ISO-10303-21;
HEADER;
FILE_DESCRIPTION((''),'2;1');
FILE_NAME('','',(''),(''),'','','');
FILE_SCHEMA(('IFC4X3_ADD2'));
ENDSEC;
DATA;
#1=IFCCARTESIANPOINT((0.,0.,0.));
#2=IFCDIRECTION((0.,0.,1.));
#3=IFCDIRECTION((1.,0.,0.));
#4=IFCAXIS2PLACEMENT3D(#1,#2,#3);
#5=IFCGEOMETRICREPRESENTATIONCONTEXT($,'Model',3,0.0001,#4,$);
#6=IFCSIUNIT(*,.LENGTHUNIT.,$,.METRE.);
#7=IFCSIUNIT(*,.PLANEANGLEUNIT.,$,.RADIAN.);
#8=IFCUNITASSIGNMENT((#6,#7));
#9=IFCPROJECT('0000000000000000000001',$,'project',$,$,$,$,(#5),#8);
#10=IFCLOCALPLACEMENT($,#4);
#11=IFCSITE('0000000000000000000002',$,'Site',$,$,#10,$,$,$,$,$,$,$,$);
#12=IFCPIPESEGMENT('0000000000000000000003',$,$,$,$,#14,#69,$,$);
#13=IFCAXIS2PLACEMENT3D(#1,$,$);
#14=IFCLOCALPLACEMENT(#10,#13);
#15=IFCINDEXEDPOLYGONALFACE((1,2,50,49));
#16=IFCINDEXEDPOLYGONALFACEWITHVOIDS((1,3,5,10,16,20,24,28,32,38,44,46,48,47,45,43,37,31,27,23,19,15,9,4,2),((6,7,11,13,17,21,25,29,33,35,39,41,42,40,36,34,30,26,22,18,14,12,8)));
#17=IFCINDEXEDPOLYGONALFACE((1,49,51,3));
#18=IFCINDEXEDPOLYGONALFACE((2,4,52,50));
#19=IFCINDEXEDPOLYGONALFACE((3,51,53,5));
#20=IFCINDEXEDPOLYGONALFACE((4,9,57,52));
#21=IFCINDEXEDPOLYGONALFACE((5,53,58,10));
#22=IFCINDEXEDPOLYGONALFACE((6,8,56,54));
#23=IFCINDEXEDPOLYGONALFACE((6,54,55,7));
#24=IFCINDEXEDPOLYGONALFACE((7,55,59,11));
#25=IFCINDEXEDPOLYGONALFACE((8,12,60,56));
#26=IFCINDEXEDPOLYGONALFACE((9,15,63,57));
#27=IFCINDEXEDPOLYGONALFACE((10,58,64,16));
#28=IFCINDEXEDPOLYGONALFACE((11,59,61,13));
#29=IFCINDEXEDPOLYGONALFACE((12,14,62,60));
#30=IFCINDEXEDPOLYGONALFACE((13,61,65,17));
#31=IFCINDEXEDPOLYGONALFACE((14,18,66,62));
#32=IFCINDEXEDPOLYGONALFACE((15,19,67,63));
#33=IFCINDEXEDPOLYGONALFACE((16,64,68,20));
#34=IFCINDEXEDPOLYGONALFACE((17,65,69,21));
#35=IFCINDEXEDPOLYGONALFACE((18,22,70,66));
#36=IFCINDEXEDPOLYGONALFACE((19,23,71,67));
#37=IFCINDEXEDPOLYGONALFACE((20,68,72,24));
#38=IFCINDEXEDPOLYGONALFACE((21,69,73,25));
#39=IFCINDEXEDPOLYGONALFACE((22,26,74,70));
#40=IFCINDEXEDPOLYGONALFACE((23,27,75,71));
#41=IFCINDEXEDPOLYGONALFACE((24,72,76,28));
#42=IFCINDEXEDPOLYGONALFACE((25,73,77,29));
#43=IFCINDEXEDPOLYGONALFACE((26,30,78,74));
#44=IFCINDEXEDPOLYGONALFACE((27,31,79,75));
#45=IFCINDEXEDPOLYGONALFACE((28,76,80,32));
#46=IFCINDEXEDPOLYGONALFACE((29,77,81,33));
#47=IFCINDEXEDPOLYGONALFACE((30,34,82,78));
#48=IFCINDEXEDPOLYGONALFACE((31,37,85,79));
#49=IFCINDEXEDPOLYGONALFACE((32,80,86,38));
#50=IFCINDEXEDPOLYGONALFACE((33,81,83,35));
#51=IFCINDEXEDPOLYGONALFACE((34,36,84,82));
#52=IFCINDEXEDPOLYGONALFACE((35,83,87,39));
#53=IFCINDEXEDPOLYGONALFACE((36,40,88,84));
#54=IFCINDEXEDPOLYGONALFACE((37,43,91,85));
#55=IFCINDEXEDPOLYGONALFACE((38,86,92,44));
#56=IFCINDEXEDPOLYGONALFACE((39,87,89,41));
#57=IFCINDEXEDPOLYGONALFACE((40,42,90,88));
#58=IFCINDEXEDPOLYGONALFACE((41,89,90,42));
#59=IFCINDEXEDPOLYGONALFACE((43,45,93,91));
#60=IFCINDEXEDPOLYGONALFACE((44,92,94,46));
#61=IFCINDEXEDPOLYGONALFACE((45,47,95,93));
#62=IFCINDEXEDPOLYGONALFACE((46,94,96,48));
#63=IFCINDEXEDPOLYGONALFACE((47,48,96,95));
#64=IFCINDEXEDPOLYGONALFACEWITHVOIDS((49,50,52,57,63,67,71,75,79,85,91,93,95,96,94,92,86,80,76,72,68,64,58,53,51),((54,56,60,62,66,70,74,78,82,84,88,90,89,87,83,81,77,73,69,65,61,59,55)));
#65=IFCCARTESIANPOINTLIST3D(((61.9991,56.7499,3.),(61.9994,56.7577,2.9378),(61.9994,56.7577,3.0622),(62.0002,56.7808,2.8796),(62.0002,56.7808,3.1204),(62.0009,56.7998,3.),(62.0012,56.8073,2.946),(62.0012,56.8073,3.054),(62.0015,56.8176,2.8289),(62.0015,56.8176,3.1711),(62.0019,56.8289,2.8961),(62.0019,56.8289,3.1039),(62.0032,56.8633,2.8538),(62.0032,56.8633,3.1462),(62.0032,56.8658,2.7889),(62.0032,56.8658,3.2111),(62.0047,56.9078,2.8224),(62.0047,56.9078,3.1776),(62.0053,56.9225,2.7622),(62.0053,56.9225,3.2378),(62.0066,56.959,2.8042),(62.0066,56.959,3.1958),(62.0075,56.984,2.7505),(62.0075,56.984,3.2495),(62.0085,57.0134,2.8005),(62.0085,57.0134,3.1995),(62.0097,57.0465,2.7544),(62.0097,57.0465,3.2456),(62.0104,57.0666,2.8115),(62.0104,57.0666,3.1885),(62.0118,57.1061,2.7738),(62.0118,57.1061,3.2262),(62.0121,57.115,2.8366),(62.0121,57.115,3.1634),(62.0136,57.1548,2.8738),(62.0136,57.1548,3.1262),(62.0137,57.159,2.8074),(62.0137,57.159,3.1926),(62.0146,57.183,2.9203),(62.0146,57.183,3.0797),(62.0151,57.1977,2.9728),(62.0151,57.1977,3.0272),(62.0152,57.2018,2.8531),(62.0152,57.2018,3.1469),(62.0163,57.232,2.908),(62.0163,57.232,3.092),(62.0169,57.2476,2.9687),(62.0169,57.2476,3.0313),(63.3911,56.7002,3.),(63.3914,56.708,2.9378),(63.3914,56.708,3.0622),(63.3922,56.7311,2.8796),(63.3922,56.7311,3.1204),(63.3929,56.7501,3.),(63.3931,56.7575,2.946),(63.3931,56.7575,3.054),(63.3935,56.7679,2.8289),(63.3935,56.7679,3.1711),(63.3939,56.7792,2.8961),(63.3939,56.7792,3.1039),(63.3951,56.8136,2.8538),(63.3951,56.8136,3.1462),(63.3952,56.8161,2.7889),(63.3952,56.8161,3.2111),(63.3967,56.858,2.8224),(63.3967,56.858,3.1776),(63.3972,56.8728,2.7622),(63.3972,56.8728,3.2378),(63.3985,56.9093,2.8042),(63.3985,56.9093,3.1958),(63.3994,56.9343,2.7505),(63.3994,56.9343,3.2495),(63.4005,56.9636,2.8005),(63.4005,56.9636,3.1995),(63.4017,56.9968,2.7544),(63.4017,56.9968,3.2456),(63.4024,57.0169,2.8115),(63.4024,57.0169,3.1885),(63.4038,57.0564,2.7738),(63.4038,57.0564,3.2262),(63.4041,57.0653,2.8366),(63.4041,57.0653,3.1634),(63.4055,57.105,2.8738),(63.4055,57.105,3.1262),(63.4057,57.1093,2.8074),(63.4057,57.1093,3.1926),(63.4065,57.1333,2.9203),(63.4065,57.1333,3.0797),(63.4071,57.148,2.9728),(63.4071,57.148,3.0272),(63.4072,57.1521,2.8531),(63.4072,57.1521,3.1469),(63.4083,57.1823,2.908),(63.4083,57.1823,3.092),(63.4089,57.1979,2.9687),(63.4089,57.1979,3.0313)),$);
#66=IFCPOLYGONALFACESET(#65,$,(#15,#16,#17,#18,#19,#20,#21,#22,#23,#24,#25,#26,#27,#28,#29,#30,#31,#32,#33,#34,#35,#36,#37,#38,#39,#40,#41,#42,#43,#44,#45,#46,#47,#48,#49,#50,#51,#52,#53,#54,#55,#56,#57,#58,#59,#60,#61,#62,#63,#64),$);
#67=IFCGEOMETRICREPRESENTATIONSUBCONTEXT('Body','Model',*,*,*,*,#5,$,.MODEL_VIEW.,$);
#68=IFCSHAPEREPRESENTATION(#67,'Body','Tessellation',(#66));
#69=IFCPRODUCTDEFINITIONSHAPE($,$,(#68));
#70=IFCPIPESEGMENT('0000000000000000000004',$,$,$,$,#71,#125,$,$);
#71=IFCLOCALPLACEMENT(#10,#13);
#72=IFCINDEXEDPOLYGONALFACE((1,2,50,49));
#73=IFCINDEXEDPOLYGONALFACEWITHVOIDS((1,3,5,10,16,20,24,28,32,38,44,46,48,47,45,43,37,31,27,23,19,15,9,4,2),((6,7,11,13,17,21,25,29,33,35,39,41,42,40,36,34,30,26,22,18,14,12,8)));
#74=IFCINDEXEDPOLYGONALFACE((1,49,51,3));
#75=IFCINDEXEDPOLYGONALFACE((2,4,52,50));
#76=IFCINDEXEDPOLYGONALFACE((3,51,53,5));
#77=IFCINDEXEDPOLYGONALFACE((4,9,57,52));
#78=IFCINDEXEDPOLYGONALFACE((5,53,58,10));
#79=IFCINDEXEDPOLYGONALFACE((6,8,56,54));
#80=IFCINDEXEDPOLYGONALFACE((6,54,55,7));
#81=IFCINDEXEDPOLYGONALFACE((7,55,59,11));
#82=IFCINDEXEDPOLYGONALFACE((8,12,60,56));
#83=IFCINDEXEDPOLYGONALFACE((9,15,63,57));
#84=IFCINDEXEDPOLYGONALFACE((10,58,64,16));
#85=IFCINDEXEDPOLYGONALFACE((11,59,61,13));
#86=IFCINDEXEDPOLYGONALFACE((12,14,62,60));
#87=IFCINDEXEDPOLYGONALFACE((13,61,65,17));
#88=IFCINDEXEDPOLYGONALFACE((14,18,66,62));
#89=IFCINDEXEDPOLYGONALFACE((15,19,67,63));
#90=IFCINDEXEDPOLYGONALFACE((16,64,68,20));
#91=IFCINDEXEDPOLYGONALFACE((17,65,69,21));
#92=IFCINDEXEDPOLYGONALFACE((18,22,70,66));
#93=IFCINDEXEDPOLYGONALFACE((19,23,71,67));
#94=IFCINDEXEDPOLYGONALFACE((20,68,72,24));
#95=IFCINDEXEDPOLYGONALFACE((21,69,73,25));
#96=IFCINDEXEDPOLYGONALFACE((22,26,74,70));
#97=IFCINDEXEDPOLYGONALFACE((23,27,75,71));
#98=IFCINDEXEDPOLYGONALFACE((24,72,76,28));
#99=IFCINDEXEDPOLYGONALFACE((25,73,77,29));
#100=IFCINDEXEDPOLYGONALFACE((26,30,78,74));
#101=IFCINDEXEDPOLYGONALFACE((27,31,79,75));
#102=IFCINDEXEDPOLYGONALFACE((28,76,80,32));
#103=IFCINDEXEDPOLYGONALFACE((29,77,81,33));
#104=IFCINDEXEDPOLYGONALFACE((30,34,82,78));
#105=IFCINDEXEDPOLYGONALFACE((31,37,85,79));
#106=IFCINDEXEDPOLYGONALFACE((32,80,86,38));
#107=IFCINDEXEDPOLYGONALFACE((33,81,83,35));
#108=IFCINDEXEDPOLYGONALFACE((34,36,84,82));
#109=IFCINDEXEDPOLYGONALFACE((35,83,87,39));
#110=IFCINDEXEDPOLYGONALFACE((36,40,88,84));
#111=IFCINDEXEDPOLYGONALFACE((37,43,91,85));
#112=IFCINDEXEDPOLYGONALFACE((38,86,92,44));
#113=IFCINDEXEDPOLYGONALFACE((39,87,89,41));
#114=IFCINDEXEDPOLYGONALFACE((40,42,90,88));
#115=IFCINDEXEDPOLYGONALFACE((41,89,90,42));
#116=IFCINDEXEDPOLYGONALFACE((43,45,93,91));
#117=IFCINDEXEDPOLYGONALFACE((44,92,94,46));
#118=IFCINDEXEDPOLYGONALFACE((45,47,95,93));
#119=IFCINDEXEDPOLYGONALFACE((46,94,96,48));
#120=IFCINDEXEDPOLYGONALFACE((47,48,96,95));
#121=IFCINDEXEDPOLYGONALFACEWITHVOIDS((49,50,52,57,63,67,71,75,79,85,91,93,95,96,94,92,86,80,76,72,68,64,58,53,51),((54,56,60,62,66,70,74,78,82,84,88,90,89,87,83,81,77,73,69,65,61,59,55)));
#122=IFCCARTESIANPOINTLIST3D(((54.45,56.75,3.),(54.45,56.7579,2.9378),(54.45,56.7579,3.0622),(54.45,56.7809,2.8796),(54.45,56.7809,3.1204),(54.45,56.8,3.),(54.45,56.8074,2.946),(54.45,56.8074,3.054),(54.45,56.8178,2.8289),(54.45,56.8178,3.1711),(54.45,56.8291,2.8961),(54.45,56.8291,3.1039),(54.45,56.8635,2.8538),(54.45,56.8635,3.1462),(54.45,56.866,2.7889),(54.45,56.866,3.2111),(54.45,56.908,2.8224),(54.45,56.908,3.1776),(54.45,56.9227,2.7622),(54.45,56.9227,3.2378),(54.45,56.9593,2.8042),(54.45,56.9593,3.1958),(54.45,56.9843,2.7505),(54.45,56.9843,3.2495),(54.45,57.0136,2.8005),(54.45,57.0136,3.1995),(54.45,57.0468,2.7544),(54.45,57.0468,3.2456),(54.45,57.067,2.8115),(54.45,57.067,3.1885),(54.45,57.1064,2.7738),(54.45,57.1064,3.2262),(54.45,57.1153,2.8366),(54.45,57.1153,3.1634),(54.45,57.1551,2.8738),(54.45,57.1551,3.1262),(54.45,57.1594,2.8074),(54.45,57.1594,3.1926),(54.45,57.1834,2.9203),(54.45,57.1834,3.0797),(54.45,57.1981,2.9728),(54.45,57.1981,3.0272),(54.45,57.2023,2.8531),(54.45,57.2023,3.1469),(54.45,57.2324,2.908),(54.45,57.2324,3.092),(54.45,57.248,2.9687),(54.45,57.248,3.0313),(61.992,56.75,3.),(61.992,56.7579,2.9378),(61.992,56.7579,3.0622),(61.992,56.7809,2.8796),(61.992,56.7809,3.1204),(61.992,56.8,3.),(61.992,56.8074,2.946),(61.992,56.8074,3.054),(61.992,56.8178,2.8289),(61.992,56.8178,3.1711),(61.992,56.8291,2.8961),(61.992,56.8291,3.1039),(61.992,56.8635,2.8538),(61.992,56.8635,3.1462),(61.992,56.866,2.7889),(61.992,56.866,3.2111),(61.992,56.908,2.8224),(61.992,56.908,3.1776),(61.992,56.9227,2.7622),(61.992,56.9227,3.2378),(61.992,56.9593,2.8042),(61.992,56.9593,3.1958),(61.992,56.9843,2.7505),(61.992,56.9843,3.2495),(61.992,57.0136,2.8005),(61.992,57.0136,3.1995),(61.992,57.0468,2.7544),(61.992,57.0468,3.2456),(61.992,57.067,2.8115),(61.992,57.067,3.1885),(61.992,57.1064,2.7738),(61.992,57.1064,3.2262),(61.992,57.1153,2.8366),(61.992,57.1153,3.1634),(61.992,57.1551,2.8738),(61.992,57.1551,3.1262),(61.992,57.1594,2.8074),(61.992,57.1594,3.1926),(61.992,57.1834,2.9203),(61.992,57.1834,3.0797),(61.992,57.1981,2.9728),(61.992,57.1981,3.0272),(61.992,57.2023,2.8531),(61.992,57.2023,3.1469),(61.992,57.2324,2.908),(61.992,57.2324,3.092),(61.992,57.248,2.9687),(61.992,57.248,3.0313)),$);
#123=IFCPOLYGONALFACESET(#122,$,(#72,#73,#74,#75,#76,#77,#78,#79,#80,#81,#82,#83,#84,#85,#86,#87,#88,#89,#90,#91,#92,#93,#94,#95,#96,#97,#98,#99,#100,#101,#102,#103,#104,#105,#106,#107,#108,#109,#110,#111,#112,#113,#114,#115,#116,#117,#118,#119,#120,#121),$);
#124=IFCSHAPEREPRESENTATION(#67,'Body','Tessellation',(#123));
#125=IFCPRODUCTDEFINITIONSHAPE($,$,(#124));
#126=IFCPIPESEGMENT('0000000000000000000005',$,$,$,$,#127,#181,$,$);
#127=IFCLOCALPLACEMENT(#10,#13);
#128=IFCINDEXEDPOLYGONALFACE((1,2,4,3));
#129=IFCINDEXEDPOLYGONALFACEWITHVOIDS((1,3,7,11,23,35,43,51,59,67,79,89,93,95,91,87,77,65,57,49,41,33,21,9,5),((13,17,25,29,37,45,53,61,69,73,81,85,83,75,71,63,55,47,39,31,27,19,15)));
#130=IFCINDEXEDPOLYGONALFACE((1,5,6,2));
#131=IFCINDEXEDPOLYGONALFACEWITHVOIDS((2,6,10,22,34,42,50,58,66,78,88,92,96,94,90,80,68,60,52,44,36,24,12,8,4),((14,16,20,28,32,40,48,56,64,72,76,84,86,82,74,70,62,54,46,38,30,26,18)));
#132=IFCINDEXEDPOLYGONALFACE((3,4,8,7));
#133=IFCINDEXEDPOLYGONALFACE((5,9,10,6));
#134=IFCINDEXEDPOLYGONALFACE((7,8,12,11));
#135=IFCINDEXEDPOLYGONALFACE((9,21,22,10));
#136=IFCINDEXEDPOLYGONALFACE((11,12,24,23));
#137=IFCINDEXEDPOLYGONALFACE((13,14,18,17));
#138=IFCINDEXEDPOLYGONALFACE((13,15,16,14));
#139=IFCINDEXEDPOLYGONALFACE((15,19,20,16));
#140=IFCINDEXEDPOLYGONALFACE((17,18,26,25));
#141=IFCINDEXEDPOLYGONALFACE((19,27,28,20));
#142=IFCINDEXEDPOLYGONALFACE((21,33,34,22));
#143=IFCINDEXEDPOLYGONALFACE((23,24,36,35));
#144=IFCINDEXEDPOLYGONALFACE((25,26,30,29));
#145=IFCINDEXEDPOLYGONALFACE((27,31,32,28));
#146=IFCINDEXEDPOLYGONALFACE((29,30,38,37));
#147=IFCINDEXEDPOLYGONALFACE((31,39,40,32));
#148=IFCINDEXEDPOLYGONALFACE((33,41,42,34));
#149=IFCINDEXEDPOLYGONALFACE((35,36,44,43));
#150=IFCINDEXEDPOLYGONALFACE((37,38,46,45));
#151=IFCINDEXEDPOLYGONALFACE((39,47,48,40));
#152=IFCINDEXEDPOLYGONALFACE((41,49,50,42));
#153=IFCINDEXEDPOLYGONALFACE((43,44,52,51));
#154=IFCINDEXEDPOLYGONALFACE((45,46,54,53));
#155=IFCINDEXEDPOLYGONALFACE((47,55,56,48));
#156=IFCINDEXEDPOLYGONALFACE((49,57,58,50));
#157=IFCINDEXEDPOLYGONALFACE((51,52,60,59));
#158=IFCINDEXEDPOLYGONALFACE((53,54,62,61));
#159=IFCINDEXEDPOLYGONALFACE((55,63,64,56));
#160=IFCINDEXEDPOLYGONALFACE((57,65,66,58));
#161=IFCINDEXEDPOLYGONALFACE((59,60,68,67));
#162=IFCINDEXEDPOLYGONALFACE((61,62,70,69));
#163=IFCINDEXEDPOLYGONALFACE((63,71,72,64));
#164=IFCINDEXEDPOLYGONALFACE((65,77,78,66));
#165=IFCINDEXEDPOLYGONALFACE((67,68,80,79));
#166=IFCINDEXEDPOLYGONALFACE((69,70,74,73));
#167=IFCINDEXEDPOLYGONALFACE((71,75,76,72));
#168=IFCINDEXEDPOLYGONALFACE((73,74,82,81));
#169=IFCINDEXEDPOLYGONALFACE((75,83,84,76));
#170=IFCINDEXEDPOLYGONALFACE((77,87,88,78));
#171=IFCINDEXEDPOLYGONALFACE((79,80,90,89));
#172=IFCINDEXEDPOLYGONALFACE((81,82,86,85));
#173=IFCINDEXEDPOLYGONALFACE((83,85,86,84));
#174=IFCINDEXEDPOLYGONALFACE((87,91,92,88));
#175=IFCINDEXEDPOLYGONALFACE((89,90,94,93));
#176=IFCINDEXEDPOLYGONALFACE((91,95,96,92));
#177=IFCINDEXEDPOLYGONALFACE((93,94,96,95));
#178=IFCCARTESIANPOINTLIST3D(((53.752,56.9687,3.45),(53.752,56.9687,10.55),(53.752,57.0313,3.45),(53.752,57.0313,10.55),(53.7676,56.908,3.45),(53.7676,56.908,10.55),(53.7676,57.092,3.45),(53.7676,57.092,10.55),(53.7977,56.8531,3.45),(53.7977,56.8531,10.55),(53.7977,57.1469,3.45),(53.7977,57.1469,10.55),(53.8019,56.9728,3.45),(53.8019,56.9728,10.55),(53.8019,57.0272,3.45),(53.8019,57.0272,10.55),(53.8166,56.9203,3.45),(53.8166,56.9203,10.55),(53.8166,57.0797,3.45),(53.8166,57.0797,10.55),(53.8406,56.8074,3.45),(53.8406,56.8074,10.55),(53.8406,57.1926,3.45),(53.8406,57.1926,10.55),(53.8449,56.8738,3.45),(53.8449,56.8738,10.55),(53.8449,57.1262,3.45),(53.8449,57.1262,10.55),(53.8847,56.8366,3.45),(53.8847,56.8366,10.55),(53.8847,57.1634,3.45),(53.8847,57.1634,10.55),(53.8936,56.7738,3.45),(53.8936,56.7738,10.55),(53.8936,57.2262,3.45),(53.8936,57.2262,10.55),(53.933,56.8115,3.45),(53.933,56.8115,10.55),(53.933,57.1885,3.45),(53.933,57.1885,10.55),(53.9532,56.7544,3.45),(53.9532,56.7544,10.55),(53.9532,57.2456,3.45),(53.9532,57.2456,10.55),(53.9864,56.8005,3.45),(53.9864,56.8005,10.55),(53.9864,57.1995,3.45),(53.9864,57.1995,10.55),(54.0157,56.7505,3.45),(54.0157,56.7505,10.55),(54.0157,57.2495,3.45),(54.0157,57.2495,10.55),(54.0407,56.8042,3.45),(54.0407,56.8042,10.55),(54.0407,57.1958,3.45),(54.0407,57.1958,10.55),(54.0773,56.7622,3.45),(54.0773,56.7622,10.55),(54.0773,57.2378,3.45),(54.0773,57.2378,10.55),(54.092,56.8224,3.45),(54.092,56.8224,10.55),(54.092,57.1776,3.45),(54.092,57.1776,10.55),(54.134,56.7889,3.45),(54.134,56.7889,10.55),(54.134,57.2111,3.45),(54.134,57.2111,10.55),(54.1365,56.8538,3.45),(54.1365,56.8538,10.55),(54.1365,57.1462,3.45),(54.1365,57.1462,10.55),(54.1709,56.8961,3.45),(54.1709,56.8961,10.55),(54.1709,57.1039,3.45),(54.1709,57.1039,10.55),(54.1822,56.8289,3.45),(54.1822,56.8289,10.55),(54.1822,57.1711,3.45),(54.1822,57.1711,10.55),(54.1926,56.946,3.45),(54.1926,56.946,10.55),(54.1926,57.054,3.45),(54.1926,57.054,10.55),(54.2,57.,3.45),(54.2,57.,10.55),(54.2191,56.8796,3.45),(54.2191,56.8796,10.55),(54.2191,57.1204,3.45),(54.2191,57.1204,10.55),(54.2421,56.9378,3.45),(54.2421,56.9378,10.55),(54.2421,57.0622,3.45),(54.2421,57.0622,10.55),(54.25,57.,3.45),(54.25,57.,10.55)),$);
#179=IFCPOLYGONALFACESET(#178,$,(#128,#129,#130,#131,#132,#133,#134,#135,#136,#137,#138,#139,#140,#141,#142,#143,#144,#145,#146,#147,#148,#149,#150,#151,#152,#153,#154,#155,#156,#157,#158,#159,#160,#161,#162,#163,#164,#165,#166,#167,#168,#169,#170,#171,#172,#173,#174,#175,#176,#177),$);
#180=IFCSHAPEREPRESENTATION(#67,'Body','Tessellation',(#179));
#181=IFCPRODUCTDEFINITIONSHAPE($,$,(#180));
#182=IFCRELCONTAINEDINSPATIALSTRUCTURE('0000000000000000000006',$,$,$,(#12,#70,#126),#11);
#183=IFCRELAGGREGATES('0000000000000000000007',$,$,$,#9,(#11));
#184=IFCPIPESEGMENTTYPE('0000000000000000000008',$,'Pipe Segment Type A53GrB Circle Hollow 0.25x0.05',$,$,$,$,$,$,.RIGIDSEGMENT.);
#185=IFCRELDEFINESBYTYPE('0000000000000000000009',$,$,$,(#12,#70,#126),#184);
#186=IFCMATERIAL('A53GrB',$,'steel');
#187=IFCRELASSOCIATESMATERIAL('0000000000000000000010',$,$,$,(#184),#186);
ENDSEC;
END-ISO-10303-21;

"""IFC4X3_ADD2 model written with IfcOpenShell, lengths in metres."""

from ifc_helpers import new_model, si_unit, frame, origin_with_axes, place, context, subcontext, project, spatial, hollow_circle, extrude, material, material_profile, profile_set, type_object, element, save


model = new_model("IFC4X3_ADD2")

# Units and contexts
model_context = context("Model", 3, precision=0.0001, world=origin_with_axes())
body_context = subcontext(model_context, "Body", "Model", "MODEL_VIEW")
ifc_project = project(units=[si_unit("LENGTHUNIT", "METRE"), si_unit("PLANEANGLEUNIT", "RADIAN")], contexts=[model_context])

# Site
site_placement = place(None, origin_with_axes())
site = spatial("IfcSite", under=ifc_project, at=site_placement, Name="Site")

# Pipe segments
ifc_material = material(Name="A53GrB", Category="steel")
ifc_material_profile = material_profile(ifc_material, hollow_circle(Radius=0.25, WallThickness=0.05))
ifc_profile_set = profile_set([ifc_material_profile], Name="A53GrB steel Circle Hollow 0.25x0.05")
pipe_segment_type = type_object("IfcPipeSegmentType", Name="Pipe Segment Type A53GrB Circle Hollow 0.25x0.05", PredefinedType="RIGIDSEGMENT", material=ifc_profile_set)
pipe_segment_1_placement = place(None, frame((63.4, 56.95, 3.0), z_axis=(-0.999363, 0.035692, 0.0), x_axis=(-0.035692, -0.999363, 0.0)))
element("IfcPipeSegment", 1, at=pipe_segment_1_placement, inside=site, type_object=pipe_segment_type, context=body_context, shape_type="SweptSolid", body=[
    extrude(hollow_circle(Radius=0.25, WallThickness=0.05), origin_with_axes(), (0.0, 0.0, 1.0), 1.3929),
])
pipe_segment_2_placement = place(None, frame((61.992, 57.0, 3.0), z_axis=(-1.0, 0.0, 0.0), x_axis=(0.0, -1.0, 0.0)))
element("IfcPipeSegment", 2, at=pipe_segment_2_placement, inside=site, type_object=pipe_segment_type, context=body_context, shape_type="SweptSolid", body=[
    extrude(hollow_circle(Radius=0.25, WallThickness=0.05), origin_with_axes(), (0.0, 0.0, 1.0), 7.542),
])
pipe_segment_3_placement = place(None, frame((54.0, 57.0, 3.45), z_axis=(0.0, 0.0, 1.0), x_axis=(1.0, 0.0, 0.0)))
element("IfcPipeSegment", 3, at=pipe_segment_3_placement, inside=site, type_object=pipe_segment_type, context=body_context, shape_type="SweptSolid", body=[
    extrude(hollow_circle(Radius=0.25, WallThickness=0.05), origin_with_axes(), (0.0, 0.0, 1.0), 7.1),
])

save(model, "model.ifc")
